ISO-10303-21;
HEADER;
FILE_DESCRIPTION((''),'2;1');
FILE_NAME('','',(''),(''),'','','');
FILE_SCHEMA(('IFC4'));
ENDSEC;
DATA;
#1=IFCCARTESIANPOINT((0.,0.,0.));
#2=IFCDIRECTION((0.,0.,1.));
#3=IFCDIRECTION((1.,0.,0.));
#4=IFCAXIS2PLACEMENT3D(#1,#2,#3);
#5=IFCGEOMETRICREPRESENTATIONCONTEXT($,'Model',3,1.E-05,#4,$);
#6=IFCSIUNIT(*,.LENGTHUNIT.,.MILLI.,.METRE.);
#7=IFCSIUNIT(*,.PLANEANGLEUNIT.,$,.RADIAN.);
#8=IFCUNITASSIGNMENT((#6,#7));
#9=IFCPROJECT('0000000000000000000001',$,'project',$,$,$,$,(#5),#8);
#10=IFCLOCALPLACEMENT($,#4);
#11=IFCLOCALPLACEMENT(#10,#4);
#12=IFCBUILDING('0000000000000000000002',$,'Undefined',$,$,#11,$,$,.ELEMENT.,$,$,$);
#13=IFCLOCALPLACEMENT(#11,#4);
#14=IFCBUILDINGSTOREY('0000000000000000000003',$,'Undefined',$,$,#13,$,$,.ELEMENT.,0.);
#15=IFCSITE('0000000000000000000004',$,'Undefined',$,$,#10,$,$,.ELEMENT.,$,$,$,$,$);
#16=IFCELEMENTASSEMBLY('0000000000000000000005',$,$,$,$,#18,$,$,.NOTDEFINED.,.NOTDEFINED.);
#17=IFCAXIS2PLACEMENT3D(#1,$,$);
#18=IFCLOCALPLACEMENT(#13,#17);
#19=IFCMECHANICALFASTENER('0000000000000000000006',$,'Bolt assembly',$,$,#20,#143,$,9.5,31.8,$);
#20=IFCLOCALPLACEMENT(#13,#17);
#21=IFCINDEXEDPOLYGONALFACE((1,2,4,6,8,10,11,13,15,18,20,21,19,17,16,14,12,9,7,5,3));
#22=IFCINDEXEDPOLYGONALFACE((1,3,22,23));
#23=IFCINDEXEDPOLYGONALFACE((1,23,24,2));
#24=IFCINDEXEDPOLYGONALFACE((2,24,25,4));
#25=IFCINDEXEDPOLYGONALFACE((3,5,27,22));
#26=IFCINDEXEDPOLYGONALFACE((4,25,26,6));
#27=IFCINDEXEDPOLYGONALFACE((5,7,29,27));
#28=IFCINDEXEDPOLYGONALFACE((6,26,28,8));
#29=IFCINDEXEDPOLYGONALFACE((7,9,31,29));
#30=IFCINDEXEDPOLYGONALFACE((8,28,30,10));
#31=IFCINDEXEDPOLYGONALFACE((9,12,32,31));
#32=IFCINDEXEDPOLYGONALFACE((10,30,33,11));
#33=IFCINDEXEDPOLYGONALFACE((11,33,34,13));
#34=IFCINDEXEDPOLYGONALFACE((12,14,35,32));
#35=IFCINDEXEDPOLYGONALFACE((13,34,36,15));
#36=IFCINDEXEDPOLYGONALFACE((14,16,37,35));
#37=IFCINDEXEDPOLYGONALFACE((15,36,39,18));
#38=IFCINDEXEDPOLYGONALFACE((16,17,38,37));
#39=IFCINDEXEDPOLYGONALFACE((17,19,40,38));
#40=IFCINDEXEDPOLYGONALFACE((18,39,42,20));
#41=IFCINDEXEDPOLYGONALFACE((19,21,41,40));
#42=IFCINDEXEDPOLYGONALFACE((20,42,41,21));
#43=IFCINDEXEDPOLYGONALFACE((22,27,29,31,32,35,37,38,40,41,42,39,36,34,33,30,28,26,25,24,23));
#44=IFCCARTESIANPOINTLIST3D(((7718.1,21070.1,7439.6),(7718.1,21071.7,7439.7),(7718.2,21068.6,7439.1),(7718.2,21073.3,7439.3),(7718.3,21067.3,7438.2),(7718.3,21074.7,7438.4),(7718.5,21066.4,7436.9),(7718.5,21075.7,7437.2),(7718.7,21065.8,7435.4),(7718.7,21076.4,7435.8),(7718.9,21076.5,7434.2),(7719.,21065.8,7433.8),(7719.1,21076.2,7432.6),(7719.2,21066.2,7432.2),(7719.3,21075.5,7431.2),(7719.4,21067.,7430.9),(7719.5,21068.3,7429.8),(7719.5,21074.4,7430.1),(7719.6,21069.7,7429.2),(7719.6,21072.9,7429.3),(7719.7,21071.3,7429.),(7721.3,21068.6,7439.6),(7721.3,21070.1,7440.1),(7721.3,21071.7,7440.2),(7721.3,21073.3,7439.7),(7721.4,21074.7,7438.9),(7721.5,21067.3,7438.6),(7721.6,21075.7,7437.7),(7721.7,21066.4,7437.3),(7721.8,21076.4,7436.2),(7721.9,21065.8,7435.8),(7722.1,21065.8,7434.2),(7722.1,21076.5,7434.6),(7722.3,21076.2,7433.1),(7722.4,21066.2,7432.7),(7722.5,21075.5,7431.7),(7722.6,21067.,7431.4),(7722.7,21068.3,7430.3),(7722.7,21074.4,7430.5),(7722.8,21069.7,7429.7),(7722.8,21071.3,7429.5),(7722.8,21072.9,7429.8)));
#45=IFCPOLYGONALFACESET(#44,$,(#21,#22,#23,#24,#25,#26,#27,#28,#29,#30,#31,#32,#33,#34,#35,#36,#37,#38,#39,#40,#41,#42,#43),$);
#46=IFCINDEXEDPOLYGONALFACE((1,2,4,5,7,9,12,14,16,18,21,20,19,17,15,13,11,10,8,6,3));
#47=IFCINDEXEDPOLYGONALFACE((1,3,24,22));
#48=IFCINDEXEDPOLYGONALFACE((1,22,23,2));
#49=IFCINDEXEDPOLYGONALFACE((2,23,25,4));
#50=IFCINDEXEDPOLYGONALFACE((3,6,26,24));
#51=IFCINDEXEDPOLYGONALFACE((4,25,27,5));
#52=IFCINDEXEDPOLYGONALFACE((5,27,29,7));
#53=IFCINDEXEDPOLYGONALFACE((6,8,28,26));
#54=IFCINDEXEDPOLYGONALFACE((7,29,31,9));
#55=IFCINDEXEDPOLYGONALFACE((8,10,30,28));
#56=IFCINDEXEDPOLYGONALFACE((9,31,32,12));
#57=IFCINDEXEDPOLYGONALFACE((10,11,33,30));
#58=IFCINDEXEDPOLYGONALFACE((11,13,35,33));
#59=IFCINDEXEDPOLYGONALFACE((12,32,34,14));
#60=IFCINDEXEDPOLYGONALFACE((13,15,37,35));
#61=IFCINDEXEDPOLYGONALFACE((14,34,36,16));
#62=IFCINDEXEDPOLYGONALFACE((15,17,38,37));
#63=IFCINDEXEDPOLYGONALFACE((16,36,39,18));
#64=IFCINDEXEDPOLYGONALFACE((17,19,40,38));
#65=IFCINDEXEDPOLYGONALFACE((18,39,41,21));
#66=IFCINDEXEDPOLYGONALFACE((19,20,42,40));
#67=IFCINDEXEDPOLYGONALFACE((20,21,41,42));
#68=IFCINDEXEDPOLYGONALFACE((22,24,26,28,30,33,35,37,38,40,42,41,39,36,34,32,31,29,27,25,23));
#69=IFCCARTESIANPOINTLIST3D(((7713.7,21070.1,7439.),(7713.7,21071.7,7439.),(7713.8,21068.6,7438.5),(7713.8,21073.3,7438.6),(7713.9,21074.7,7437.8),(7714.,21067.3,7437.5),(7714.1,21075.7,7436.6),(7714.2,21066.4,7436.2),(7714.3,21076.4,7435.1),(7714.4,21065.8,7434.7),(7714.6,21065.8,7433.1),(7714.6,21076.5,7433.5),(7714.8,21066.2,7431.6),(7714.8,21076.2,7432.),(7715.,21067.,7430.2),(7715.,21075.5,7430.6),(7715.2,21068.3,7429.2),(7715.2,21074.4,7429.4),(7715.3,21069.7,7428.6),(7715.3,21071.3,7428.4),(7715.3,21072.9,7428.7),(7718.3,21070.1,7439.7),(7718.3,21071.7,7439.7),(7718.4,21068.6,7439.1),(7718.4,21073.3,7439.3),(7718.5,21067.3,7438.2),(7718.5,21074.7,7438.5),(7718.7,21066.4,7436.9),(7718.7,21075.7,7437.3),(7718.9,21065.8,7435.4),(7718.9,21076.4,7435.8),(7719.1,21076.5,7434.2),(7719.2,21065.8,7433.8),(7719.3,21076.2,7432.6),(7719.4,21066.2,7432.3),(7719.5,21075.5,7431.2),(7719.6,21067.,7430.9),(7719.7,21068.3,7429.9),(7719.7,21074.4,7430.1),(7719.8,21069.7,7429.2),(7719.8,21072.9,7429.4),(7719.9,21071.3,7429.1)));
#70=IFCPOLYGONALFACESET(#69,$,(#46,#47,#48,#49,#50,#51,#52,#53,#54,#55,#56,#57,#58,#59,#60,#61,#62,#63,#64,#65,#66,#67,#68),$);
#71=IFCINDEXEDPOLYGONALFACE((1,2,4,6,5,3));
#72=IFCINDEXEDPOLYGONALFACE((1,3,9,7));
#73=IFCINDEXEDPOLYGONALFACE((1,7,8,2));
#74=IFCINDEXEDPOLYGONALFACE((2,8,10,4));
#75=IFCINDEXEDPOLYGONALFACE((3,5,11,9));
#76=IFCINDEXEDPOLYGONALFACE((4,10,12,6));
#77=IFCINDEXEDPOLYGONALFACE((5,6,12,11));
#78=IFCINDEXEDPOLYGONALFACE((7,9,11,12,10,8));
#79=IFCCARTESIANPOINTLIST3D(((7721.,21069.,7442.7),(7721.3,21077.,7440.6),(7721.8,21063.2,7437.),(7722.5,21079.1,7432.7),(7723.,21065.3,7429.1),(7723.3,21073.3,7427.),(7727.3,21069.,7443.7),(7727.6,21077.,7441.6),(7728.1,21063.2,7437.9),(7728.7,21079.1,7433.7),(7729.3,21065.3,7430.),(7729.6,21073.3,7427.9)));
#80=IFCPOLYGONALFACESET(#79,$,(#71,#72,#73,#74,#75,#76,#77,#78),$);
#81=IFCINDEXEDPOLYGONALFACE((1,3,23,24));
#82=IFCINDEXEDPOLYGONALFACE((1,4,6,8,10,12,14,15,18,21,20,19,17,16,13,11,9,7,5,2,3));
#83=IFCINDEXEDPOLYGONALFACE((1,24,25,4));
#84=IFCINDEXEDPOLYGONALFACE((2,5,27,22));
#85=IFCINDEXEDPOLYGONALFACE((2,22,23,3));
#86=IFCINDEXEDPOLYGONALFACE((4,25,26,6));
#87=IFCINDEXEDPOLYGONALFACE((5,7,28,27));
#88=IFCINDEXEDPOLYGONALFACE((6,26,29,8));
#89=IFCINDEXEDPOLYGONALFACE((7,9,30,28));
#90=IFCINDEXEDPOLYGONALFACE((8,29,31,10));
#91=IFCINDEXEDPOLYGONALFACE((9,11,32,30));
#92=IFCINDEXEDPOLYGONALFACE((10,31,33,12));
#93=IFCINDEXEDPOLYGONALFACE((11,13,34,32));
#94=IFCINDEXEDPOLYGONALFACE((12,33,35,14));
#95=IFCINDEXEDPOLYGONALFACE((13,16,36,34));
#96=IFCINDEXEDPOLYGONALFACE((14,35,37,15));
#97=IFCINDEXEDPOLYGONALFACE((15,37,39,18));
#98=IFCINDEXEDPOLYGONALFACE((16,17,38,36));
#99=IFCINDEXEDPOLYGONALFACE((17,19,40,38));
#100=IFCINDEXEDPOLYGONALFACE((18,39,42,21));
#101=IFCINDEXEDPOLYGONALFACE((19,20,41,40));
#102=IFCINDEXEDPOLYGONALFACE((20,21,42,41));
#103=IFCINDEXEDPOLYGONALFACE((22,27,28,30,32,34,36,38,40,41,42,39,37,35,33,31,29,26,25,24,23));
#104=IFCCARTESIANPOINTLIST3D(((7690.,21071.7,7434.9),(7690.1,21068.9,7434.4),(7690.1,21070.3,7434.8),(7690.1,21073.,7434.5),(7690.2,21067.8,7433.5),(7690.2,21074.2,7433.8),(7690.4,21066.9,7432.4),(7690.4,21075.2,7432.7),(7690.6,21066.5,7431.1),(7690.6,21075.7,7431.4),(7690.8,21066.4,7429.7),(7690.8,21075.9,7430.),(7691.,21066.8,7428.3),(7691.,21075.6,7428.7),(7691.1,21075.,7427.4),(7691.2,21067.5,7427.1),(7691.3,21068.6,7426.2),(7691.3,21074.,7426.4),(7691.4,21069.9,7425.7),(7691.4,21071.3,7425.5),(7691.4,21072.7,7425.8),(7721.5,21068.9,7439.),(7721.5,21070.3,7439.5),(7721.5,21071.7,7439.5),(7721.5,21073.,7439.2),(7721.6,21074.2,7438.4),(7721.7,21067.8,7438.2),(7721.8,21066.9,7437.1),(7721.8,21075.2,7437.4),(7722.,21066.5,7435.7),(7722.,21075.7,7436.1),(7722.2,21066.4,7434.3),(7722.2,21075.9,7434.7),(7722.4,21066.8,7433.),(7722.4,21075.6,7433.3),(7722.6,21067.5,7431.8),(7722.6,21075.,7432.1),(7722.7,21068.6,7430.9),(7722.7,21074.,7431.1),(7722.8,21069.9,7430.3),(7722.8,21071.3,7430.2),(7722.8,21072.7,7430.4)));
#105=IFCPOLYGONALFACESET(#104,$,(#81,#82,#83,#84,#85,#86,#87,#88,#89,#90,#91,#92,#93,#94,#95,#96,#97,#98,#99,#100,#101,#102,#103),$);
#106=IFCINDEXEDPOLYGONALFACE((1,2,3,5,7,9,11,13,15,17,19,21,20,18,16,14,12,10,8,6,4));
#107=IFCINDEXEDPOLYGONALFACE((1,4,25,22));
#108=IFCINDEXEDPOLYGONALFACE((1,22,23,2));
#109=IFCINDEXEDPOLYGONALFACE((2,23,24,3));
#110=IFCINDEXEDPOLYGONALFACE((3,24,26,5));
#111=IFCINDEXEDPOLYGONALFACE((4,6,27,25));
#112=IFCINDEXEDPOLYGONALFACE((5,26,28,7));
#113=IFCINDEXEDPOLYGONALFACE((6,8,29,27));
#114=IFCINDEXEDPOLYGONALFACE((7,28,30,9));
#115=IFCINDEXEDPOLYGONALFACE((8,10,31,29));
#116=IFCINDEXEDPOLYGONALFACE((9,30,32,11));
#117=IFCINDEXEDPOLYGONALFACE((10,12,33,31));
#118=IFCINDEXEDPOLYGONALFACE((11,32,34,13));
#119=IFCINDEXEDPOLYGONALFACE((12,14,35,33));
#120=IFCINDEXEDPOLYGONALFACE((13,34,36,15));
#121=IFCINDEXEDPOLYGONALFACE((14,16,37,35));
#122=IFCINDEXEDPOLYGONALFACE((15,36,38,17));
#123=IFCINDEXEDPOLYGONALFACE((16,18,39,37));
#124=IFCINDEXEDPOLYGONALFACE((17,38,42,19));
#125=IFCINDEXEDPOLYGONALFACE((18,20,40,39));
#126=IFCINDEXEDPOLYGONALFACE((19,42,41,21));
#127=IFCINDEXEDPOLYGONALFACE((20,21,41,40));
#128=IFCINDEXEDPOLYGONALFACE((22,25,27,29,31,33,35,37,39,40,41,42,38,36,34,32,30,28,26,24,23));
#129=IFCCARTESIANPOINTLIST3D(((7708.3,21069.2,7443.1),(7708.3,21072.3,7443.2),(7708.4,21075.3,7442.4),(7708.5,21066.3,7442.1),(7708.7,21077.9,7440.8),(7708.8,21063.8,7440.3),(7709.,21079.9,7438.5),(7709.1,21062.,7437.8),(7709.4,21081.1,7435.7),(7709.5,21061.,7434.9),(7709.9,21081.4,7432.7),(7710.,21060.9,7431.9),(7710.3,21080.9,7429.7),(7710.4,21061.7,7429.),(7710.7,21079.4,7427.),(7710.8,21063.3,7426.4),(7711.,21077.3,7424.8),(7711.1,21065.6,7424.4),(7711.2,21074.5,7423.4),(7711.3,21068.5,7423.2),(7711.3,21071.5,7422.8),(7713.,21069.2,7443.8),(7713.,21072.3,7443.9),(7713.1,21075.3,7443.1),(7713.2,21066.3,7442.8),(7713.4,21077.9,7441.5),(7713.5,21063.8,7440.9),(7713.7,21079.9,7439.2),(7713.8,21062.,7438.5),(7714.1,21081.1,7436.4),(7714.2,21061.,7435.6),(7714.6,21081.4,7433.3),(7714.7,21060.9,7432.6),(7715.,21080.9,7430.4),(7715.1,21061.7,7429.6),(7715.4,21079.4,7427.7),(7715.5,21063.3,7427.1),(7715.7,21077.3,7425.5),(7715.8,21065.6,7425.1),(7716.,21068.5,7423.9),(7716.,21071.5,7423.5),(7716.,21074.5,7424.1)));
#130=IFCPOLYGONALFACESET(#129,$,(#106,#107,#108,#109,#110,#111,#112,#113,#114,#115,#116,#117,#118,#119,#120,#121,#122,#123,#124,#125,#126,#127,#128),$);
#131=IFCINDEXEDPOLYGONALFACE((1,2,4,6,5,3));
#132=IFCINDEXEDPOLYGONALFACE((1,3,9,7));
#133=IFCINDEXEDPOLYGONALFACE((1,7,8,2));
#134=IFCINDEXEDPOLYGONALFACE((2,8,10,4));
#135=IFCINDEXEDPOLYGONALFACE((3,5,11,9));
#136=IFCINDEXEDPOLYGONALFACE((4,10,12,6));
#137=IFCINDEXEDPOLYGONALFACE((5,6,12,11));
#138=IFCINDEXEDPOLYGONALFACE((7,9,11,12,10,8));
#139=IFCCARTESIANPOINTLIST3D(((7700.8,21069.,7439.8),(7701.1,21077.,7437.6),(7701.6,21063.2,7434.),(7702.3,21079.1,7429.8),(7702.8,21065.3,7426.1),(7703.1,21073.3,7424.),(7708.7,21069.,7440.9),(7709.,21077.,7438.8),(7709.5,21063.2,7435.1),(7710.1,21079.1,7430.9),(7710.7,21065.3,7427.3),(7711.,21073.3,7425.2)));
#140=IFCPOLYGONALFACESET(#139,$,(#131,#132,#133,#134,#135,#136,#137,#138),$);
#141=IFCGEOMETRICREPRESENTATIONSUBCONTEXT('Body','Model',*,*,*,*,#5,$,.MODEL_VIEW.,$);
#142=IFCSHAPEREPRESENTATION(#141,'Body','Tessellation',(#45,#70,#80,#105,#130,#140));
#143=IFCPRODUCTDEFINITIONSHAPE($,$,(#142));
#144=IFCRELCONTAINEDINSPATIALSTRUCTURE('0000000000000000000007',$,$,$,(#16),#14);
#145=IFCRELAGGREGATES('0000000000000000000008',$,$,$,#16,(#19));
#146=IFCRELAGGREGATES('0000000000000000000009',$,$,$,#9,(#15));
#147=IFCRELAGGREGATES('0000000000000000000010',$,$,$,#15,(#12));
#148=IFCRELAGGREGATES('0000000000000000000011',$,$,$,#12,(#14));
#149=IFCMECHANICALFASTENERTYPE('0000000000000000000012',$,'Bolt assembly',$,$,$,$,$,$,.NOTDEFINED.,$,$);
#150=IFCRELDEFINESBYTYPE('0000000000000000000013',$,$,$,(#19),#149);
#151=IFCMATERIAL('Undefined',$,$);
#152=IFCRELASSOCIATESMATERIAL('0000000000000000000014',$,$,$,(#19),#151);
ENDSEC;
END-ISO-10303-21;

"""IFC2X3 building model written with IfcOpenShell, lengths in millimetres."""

from ifc_helpers import new_model, si_unit, frame, origin_with_axes, origin_2d_with_axis, place, context, subcontext, project, spatial, polyline, circle, outline, extrude, source, transform, mapped, material, type_object, element, aggregate, save


model = new_model("IFC2X3")

# Units and contexts
model_context = context("Model", 3, precision=1e-05, world=origin_with_axes())
body_context = subcontext(model_context, "Body", "Model", "MODEL_VIEW")
ifc_project = project(units=[si_unit("LENGTHUNIT", "METRE", prefix="MILLI"), si_unit("PLANEANGLEUNIT", "RADIAN")], contexts=[model_context])

# Site, building, storey
site_placement = place(None, origin_with_axes())
site = spatial("IfcSite", under=ifc_project, at=site_placement, Name="Undefined", CompositionType="ELEMENT")
building_placement = place(site_placement, origin_with_axes())
building = spatial("IfcBuilding", under=site, at=building_placement, Name="Undefined", CompositionType="ELEMENT")
storey_placement = place(building_placement, origin_with_axes())
storey = spatial("IfcBuildingStorey", under=building, at=storey_placement, Name="Undefined", CompositionType="ELEMENT", Elevation=0.0)

# Element assembly
assembly_1_placement = place(storey_placement, origin_with_axes())
assembly_1 = element("IfcElementAssembly", 1, at=assembly_1_placement, inside=storey, AssemblyPlace="NOTDEFINED", PredefinedType="NOTDEFINED")

# Shared definitions
ifc_material_1 = material(Name="Undefined")
mechanical_fastener_type = type_object("IfcMechanicalFastenerType", Name="Bolt assembly")

# Mechanical fastener
shared_shape_1 = source(origin_with_axes(), body_context, "Body", "SweptSolid", [
    extrude(circle(Radius=5.4, at=origin_2d_with_axis()), frame((0.0, -3.1, 0.0), z_axis=(0.0, 1.0, 0.0), x_axis=(1.0, 0.0, 0.0)), (0.0, 0.0, 1.0), 3.2),
    extrude(circle(Radius=5.4, at=origin_2d_with_axis()), frame((0.0, -0.1, 0.0), z_axis=(0.0, 1.0, 0.0), x_axis=(1.0, 0.0, 0.0)), (0.0, 0.0, 1.0), 4.6),
    extrude(outline(polyline([(7.1, -4.1), (7.1, 4.1), (0.0, 8.2), (-7.1, 4.1), (-7.1, -4.1), (0.0, -8.2), (7.1, -4.1)])), frame((0.0, -9.6, 0.0), z_axis=(0.0, 1.0, 0.0), x_axis=(1.0, 0.0, 0.0)), (0.0, 0.0, 1.0), 6.3),
    extrude(circle(Radius=4.8, at=origin_2d_with_axis()), frame((0.0, -3.2, 0.0), z_axis=(0.0, 1.0, 0.0), x_axis=(1.0, 0.0, 0.0)), (0.0, 0.0, 1.0), 31.8),
    extrude(circle(Radius=10.3, at=origin_2d_with_axis()), frame((0.0, 4.5, 0.0), z_axis=(0.0, 1.0, 0.0), x_axis=(1.0, 0.0, 0.0)), (0.0, 0.0, 1.0), 4.8),
    extrude(outline(polyline([(7.1, -4.1), (7.1, 4.1), (0.0, 8.2), (-7.1, 4.1), (-7.1, -4.1), (0.0, -8.2), (7.1, -4.1)])), frame((0.0, 9.3, 0.0), z_axis=(0.0, 1.0, 0.0), x_axis=(1.0, 0.0, 0.0)), (0.0, 0.0, 1.0), 7.9),
])
mechanical_fastener_1_placement = place(assembly_1_placement, frame((7719.0, 21071.1, 7434.4), z_axis=(0.103381, -0.707107, -0.699509), x_axis=(-0.103381, -0.707107, 0.699509)))
mechanical_fastener_1 = element("IfcMechanicalFastener", 2, at=mechanical_fastener_1_placement, type_object=mechanical_fastener_type, material=ifc_material_1, Name="Bolt assembly", NominalDiameter=9.5, NominalLength=31.8, context=body_context, shape_type="MappedRepresentation", body=[
    mapped(shared_shape_1, transform((0.0, 0.0, 0.0))),
])
aggregate(assembly_1, [mechanical_fastener_1])

save(model, "model.ifc")
